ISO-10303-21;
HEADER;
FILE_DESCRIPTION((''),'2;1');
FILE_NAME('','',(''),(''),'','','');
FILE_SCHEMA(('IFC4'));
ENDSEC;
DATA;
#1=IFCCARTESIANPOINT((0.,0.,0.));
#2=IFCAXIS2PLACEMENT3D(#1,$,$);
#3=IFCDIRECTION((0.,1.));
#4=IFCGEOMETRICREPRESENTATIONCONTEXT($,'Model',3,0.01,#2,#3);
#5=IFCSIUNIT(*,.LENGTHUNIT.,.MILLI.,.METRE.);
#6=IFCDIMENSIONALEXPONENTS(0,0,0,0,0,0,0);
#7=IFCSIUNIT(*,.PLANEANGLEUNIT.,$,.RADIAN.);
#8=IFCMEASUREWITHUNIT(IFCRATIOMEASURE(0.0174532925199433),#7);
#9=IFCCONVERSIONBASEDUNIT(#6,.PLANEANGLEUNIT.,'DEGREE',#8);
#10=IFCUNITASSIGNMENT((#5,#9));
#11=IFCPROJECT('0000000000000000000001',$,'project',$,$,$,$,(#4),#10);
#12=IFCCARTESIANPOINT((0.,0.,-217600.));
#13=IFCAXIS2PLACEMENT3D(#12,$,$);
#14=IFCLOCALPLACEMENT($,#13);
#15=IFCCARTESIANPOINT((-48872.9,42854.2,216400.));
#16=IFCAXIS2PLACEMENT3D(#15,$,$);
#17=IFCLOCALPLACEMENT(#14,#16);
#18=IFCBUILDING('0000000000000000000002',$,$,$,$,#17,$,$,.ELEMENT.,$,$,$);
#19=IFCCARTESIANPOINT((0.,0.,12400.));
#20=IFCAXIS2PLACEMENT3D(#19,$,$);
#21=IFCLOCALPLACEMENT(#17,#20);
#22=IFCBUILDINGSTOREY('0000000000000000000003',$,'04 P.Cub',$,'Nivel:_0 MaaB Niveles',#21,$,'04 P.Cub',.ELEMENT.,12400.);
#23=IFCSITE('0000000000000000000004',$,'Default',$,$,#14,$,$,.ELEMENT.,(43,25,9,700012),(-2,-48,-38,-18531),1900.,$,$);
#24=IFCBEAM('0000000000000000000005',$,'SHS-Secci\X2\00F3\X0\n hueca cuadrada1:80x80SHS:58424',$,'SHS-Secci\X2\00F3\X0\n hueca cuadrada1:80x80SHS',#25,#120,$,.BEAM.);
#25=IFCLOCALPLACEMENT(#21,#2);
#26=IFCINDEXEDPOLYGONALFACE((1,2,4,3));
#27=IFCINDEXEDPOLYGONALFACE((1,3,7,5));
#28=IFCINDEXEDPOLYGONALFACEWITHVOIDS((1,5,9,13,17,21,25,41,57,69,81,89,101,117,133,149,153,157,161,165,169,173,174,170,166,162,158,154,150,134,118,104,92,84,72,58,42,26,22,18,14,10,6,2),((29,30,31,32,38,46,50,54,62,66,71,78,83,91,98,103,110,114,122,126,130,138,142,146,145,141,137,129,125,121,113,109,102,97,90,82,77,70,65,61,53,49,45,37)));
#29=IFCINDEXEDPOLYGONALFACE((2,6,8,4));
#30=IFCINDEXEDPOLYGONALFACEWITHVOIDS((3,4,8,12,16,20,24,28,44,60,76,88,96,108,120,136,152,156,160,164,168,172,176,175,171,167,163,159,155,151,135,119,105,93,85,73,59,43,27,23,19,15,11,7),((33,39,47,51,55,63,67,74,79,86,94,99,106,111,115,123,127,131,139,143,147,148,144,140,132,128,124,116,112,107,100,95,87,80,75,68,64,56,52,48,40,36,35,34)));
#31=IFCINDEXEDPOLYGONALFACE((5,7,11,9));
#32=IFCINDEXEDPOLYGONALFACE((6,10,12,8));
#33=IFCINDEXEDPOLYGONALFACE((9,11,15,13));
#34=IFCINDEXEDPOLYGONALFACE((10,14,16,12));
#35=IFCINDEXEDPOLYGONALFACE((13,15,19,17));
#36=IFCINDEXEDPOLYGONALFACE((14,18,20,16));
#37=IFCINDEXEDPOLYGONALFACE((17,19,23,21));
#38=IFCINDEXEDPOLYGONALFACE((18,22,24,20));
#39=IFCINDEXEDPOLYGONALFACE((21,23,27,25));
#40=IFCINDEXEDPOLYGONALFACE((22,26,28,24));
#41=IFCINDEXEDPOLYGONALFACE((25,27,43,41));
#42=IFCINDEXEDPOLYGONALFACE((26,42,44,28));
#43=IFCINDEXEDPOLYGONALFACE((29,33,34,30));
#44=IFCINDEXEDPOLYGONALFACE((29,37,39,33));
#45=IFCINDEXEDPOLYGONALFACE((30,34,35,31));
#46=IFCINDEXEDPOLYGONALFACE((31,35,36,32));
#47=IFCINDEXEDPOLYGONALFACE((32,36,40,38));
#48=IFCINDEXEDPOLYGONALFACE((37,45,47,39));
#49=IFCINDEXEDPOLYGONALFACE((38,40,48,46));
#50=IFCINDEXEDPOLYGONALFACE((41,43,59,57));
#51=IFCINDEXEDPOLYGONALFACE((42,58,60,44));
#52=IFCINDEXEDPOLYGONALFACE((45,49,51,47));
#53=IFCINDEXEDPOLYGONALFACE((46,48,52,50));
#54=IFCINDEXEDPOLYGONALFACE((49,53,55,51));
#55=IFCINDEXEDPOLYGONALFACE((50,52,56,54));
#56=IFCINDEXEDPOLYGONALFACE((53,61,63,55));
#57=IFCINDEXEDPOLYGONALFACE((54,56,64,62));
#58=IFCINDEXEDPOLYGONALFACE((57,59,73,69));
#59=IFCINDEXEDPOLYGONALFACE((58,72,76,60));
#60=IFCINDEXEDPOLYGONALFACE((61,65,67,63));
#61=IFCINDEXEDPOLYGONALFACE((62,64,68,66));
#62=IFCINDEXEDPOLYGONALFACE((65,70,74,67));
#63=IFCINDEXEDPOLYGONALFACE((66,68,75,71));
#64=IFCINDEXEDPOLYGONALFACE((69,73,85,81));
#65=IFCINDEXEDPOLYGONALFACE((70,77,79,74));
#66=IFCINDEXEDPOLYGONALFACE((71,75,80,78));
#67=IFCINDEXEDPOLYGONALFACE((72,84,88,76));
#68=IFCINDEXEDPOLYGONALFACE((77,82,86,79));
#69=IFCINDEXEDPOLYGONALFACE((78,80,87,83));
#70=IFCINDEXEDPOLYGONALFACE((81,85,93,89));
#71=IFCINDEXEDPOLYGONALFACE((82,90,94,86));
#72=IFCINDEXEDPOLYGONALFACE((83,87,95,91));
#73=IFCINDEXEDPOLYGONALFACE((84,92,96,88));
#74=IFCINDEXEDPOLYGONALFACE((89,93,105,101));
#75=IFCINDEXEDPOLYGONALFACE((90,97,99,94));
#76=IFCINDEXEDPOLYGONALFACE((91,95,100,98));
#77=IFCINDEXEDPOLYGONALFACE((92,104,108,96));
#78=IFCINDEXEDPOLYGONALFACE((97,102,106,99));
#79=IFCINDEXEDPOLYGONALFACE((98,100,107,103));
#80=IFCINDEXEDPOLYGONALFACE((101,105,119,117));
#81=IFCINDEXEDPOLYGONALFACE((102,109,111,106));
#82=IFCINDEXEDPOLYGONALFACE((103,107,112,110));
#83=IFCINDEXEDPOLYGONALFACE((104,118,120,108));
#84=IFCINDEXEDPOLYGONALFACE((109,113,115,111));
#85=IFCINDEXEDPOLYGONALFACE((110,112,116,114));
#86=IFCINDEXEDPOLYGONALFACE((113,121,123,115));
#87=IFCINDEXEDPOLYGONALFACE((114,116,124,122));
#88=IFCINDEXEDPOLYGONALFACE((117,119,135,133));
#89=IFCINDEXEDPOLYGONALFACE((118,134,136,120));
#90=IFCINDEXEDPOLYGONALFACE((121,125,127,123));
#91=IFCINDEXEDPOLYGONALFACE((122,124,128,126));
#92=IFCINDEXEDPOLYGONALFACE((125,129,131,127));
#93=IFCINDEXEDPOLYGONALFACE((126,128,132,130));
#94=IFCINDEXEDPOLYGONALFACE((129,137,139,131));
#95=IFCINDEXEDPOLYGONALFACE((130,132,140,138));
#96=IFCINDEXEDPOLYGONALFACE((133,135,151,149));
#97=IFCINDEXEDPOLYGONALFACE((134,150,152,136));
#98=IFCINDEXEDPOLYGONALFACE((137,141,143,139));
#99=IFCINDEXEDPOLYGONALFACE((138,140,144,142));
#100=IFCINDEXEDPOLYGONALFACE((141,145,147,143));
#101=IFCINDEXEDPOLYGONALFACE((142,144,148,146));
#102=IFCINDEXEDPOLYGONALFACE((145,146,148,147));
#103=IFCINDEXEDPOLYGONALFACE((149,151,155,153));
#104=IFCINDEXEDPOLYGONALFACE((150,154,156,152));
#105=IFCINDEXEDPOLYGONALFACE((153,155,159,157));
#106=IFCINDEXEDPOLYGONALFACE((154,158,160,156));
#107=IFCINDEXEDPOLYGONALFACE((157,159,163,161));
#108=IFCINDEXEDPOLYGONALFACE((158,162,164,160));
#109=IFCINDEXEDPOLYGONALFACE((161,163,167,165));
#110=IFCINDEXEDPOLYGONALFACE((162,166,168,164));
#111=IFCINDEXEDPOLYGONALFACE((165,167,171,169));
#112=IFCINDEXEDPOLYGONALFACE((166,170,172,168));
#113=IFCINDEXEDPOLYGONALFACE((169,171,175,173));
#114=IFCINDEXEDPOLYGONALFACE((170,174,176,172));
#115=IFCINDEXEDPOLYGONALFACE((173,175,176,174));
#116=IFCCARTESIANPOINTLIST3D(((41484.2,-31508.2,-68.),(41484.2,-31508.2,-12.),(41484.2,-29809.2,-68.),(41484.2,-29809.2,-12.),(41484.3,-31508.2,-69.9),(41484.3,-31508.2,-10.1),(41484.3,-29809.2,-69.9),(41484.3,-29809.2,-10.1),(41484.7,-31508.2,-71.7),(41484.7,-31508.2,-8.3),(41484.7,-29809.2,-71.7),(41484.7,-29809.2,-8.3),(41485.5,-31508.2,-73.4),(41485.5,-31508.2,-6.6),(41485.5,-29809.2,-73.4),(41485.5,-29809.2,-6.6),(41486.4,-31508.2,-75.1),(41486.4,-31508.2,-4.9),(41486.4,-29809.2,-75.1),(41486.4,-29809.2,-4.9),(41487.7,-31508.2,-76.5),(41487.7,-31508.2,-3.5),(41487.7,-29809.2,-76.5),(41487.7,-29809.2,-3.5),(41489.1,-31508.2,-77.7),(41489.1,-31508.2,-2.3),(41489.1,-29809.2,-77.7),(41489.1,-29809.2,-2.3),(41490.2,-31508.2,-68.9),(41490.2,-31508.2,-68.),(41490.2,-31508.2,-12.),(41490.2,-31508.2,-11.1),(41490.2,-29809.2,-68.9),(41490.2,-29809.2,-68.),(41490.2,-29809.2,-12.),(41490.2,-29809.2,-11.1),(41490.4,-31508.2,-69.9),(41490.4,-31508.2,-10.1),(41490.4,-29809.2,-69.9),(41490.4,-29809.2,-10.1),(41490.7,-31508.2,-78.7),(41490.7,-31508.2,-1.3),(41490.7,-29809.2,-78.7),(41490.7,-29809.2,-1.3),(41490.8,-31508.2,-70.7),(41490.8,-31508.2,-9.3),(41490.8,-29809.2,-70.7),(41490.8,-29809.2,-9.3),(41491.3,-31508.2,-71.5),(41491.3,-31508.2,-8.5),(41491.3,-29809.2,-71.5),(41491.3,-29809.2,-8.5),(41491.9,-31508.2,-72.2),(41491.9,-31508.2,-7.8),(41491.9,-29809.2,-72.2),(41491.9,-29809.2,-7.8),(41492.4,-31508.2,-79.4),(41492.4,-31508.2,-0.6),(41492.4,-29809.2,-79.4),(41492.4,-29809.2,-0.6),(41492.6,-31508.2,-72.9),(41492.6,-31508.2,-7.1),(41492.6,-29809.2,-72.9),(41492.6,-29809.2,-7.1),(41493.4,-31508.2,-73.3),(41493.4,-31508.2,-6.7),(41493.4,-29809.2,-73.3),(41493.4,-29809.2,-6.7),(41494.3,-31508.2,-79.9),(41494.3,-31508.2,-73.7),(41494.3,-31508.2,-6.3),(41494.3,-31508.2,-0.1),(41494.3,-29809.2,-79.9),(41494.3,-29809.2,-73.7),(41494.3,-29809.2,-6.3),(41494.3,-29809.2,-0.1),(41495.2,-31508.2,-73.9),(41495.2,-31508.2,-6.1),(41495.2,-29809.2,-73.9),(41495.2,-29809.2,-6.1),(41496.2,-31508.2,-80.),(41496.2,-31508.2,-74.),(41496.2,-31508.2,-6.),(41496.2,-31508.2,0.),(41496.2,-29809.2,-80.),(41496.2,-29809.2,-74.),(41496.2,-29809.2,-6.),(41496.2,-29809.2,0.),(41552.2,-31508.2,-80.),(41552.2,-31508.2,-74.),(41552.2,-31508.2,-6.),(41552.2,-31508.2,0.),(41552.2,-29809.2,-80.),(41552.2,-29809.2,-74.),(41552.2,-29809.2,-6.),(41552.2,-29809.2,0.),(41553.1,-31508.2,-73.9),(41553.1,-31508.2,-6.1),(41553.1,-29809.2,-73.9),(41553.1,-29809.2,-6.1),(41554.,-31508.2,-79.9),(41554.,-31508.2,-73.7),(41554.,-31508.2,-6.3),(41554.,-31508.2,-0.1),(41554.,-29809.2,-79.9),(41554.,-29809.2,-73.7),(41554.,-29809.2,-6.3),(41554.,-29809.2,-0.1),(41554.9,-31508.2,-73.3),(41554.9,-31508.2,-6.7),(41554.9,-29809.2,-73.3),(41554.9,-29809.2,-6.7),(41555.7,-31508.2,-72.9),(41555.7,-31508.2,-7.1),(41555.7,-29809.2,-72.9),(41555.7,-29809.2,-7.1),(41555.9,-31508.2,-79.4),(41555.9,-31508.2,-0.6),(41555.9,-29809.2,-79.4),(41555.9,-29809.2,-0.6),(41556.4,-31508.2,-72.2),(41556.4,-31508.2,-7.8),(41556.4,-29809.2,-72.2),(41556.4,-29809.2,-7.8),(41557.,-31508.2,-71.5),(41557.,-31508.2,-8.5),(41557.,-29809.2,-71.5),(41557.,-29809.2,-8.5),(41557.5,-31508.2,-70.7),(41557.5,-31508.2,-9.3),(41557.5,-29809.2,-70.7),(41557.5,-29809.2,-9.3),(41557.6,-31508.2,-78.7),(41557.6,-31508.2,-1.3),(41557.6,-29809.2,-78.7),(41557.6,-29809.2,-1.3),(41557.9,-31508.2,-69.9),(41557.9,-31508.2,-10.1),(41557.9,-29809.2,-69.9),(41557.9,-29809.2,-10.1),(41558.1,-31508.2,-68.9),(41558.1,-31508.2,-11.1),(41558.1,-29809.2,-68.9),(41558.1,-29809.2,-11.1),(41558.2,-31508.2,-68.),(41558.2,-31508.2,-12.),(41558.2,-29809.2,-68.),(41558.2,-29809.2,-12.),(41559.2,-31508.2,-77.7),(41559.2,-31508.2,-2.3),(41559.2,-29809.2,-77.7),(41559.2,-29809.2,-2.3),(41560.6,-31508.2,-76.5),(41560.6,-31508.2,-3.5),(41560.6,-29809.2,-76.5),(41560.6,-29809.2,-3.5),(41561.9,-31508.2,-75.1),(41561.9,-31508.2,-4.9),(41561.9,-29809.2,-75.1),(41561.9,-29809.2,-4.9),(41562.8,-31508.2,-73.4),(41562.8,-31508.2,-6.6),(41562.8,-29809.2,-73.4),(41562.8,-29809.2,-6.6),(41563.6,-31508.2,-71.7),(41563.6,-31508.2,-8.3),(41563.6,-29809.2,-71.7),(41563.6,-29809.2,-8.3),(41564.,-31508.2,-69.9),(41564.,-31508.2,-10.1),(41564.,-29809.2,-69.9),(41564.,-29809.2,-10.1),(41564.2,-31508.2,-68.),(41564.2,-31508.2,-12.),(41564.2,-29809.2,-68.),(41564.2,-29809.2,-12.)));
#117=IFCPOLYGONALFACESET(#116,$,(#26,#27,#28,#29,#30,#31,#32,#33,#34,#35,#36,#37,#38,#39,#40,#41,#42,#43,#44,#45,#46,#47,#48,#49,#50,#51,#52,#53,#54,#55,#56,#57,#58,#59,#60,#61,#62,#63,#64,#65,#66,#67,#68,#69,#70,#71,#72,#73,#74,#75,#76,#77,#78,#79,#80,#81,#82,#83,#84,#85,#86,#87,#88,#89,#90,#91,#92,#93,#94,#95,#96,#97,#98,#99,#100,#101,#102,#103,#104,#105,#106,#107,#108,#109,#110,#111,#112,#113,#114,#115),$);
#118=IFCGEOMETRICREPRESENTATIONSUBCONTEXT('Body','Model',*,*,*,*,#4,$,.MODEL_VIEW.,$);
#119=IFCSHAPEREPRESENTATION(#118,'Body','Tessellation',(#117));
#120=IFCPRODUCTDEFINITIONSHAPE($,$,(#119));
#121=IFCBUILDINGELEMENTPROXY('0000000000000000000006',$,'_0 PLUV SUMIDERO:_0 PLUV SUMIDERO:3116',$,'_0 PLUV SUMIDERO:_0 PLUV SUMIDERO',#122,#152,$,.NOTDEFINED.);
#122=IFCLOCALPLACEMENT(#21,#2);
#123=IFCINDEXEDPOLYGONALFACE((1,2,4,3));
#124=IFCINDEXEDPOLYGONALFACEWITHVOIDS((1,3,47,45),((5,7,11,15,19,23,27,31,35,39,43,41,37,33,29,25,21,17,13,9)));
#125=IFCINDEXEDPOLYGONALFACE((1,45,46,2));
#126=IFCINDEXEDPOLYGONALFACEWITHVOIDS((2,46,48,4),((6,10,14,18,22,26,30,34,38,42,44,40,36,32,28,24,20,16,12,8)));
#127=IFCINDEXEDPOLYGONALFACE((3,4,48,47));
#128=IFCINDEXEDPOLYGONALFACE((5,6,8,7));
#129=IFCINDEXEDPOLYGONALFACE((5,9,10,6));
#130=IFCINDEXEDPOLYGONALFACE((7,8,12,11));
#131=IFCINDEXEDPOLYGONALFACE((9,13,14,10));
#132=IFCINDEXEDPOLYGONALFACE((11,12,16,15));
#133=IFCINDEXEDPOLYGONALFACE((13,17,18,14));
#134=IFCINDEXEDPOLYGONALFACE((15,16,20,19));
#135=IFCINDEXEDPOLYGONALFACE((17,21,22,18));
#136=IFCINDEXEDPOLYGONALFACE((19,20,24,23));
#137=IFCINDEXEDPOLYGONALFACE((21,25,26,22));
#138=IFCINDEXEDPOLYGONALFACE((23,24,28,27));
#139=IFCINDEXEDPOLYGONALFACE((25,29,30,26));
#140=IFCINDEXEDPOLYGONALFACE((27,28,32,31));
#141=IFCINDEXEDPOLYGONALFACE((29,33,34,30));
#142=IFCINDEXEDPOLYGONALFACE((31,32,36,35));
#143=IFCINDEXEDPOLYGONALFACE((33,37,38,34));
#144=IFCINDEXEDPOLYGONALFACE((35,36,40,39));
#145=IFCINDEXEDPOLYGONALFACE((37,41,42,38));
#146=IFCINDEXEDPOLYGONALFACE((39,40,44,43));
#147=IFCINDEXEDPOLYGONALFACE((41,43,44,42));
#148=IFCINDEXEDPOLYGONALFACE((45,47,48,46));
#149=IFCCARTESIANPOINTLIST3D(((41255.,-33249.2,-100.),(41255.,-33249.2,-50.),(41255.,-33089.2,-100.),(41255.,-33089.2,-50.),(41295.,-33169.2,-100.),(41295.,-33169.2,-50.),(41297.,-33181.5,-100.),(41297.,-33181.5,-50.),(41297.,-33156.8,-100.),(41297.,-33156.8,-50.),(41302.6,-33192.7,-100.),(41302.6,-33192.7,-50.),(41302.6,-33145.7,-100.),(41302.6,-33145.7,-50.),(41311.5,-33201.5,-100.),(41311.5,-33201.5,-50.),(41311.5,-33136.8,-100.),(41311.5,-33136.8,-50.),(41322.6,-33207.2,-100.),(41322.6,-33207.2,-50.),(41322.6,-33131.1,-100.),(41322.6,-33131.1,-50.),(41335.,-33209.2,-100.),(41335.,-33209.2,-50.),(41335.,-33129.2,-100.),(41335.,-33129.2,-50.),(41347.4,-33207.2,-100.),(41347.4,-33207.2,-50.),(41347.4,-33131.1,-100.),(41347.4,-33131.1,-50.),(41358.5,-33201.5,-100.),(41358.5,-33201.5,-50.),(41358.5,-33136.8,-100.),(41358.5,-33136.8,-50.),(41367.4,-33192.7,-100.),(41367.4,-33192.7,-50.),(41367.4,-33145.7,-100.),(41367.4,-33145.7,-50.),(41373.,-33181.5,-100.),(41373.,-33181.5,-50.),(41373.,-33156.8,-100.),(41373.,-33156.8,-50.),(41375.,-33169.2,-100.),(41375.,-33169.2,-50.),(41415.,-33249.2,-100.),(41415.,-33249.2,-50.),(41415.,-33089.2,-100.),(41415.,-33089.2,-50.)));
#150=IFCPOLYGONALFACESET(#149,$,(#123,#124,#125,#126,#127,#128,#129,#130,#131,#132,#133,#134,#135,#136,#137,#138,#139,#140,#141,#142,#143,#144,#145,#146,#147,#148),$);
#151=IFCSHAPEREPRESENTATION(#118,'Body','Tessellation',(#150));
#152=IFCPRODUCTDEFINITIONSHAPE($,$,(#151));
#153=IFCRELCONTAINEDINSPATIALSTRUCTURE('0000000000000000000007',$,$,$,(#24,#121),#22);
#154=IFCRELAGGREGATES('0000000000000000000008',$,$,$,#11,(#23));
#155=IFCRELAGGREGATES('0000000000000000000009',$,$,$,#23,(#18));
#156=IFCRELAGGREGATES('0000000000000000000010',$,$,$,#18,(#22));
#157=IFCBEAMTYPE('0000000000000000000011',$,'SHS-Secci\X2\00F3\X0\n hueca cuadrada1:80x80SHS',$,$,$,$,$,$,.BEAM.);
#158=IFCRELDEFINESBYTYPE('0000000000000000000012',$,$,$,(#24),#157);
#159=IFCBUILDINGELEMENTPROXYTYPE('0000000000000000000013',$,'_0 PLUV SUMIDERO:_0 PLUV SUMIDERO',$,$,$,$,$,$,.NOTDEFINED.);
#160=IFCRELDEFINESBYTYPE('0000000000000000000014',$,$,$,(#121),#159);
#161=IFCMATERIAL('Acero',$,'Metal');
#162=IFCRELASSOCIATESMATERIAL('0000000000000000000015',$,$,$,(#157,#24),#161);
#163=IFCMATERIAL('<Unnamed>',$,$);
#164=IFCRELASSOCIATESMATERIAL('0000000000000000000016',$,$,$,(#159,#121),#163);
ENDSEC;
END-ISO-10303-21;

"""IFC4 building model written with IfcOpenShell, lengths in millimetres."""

from ifc_helpers import new_model, entity, si_unit, converted_unit, direction, frame, origin, place, context, subcontext, project, spatial, indexed_curve, outline, extrude, source, transform, mapped, material, type_object, type_shapes, element, save


model = new_model("IFC4")

# Units and contexts
model_context = context("Model", 3, precision=0.01, world=origin(), true_north=direction((0.0, 1.0)))
body_context = subcontext(model_context, "Body", "Model", "MODEL_VIEW")
ifc_project = project(units=[si_unit("LENGTHUNIT", "METRE", prefix="MILLI"), converted_unit("PLANEANGLEUNIT", "DEGREE", entity("IfcRatioMeasure", 0.0174532925199433), si_unit("PLANEANGLEUNIT", "RADIAN"), dimensions=[0, 0, 0, 0, 0, 0, 0])], contexts=[model_context])

# Site, building, storey
site_placement = place(None, frame((0.0, 0.0, -217600.0)))
site = spatial("IfcSite", under=ifc_project, at=site_placement, Name="Default", CompositionType="ELEMENT", RefLatitude=(43, 25, 9, 700012), RefLongitude=(-2, -48, -38, -18531), RefElevation=1900.0)
building_placement = place(site_placement, frame((-48872.9, 42854.2, 216400.0)))
building = spatial("IfcBuilding", under=site, at=building_placement, CompositionType="ELEMENT")
storey_placement = place(building_placement, frame((0.0, 0.0, 12400.0)))
storey = spatial("IfcBuildingStorey", under=building, at=storey_placement, Name="04 P.Cub", ObjectType="Nivel:_0 MaaB Niveles", LongName="04 P.Cub", CompositionType="ELEMENT", Elevation=12400.0)

# Shared definitions
ifc_material_1 = material(Name="Acero", Category="Metal")

# Beam
beam_type_1 = type_object("IfcBeamType", Name="SHS-Sección hueca cuadrada1:80x80SHS", PredefinedType="BEAM", material=ifc_material_1)
shared_shape_1 = source(origin(), body_context, "Body", "SweptSolid", [
    extrude(outline(indexed_curve([(-40.0, -28.0), (-39.9, -29.9), (-39.4, -31.7), (-38.7, -33.4), (-37.7, -35.1), (-36.5, -36.5), (-35.1, -37.7), (-33.4, -38.7), (-31.7, -39.4), (-29.9, -39.9), (-28.0, -40.0), (28.0, -40.0), (29.9, -39.9), (31.7, -39.4), (33.4, -38.7), (35.1, -37.7), (36.5, -36.5), (37.7, -35.1), (38.7, -33.4), (39.4, -31.7), (39.9, -29.9), (40.0, -28.0), (40.0, 28.0), (39.9, 29.9), (39.4, 31.7), (38.7, 33.4), (37.7, 35.1), (36.5, 36.5), (35.1, 37.7), (33.4, 38.7), (31.7, 39.4), (29.9, 39.9), (28.0, 40.0), (-28.0, 40.0), (-29.9, 39.9), (-31.7, 39.4), (-33.4, 38.7), (-35.1, 37.7), (-36.5, 36.5), (-37.7, 35.1), (-38.7, 33.4), (-39.4, 31.7), (-39.9, 29.9), (-40.0, 28.0), (-40.0, -28.0)], self_intersect=False), holes=[indexed_curve([(28.0, -34.0), (-28.0, -34.0), (-28.9, -33.9), (-29.9, -33.7), (-30.7, -33.3), (-31.5, -32.9), (-32.2, -32.2), (-32.9, -31.5), (-33.3, -30.7), (-33.7, -29.9), (-33.9, -28.9), (-34.0, -28.0), (-34.0, 28.0), (-33.9, 28.9), (-33.7, 29.9), (-33.3, 30.7), (-32.9, 31.5), (-32.2, 32.2), (-31.5, 32.9), (-30.7, 33.3), (-29.9, 33.7), (-28.9, 33.9), (-28.0, 34.0), (28.0, 34.0), (28.9, 33.9), (29.9, 33.7), (30.7, 33.3), (31.5, 32.9), (32.2, 32.2), (32.9, 31.5), (33.3, 30.7), (33.7, 29.9), (33.9, 28.9), (34.0, 28.0), (34.0, -28.0), (33.9, -28.9), (33.7, -29.9), (33.3, -30.7), (32.9, -31.5), (32.2, -32.2), (31.5, -32.9), (30.7, -33.3), (29.9, -33.7), (28.9, -33.9), (28.0, -34.0)], self_intersect=False)]), frame((-827.0, 0.0, 0.0), z_axis=(1.0, 0.0, 0.0), x_axis=(0.0, -1.0, 0.0)), (0.0, 0.0, 1.0), 1699.0),
])
type_shapes(beam_type_1, [shared_shape_1])
beam_1_placement = place(storey_placement, frame((41524.2, -30636.2, -40.0), z_axis=(0.0, 0.0, 1.0), x_axis=(0.0, -1.0, 0.0)))
element("IfcBeam", 1, at=beam_1_placement, inside=storey, type_object=beam_type_1, material=ifc_material_1, Name="SHS-Sección hueca cuadrada1:80x80SHS:58424", ObjectType="SHS-Sección hueca cuadrada1:80x80SHS", PredefinedType="BEAM", context=body_context, shape_type="MappedRepresentation", body=[
    mapped(shared_shape_1, transform((0.0, 0.0, 0.0), scale=1.0)),
])

# Building element proxy
ifc_material_2 = material(Name="<Unnamed>")
building_element_proxy_type_1 = type_object("IfcBuildingElementProxyType", Name="_0 PLUV SUMIDERO:_0 PLUV SUMIDERO", PredefinedType="NOTDEFINED", material=ifc_material_2)
shared_shape_2 = source(origin(), body_context, "Body", "SweptSolid", [
    extrude(outline(indexed_curve([(-80.0, -80.0), (80.0, -80.0), (80.0, 80.0), (-80.0, 80.0), (-80.0, -80.0)], self_intersect=False), holes=[indexed_curve([(-40.0, 0.0), (-38.0, 12.4), (-32.4, 23.5), (-23.5, 32.4), (-12.4, 38.0), (0.0, 40.0), (12.4, 38.0), (23.5, 32.4), (32.4, 23.5), (38.0, 12.4), (40.0, 0.0), (38.0, -12.4), (32.4, -23.5), (23.5, -32.4), (12.4, -38.0), (0.0, -40.0), (-12.4, -38.0), (-23.5, -32.4), (-32.4, -23.5), (-38.0, -12.4), (-40.0, 0.0)], self_intersect=False)]), frame((0.0, 0.0, 0.0), z_axis=(0.0, 0.0, 1.0), x_axis=(-1.0, 0.0, 0.0)), (0.0, 0.0, 1.0), 50.0),
])
type_shapes(building_element_proxy_type_1, [shared_shape_2])
proxy_1_placement = place(storey_placement, frame((41335.0, -33169.2, -100.0)))
element("IfcBuildingElementProxy", 2, at=proxy_1_placement, inside=storey, type_object=building_element_proxy_type_1, material=ifc_material_2, Name="_0 PLUV SUMIDERO:_0 PLUV SUMIDERO:3116", ObjectType="_0 PLUV SUMIDERO:_0 PLUV SUMIDERO", PredefinedType="NOTDEFINED", context=body_context, shape_type="MappedRepresentation", body=[
    mapped(shared_shape_2, transform((0.0, 0.0, 0.0), scale=1.0)),
])

save(model, "model.ifc")
